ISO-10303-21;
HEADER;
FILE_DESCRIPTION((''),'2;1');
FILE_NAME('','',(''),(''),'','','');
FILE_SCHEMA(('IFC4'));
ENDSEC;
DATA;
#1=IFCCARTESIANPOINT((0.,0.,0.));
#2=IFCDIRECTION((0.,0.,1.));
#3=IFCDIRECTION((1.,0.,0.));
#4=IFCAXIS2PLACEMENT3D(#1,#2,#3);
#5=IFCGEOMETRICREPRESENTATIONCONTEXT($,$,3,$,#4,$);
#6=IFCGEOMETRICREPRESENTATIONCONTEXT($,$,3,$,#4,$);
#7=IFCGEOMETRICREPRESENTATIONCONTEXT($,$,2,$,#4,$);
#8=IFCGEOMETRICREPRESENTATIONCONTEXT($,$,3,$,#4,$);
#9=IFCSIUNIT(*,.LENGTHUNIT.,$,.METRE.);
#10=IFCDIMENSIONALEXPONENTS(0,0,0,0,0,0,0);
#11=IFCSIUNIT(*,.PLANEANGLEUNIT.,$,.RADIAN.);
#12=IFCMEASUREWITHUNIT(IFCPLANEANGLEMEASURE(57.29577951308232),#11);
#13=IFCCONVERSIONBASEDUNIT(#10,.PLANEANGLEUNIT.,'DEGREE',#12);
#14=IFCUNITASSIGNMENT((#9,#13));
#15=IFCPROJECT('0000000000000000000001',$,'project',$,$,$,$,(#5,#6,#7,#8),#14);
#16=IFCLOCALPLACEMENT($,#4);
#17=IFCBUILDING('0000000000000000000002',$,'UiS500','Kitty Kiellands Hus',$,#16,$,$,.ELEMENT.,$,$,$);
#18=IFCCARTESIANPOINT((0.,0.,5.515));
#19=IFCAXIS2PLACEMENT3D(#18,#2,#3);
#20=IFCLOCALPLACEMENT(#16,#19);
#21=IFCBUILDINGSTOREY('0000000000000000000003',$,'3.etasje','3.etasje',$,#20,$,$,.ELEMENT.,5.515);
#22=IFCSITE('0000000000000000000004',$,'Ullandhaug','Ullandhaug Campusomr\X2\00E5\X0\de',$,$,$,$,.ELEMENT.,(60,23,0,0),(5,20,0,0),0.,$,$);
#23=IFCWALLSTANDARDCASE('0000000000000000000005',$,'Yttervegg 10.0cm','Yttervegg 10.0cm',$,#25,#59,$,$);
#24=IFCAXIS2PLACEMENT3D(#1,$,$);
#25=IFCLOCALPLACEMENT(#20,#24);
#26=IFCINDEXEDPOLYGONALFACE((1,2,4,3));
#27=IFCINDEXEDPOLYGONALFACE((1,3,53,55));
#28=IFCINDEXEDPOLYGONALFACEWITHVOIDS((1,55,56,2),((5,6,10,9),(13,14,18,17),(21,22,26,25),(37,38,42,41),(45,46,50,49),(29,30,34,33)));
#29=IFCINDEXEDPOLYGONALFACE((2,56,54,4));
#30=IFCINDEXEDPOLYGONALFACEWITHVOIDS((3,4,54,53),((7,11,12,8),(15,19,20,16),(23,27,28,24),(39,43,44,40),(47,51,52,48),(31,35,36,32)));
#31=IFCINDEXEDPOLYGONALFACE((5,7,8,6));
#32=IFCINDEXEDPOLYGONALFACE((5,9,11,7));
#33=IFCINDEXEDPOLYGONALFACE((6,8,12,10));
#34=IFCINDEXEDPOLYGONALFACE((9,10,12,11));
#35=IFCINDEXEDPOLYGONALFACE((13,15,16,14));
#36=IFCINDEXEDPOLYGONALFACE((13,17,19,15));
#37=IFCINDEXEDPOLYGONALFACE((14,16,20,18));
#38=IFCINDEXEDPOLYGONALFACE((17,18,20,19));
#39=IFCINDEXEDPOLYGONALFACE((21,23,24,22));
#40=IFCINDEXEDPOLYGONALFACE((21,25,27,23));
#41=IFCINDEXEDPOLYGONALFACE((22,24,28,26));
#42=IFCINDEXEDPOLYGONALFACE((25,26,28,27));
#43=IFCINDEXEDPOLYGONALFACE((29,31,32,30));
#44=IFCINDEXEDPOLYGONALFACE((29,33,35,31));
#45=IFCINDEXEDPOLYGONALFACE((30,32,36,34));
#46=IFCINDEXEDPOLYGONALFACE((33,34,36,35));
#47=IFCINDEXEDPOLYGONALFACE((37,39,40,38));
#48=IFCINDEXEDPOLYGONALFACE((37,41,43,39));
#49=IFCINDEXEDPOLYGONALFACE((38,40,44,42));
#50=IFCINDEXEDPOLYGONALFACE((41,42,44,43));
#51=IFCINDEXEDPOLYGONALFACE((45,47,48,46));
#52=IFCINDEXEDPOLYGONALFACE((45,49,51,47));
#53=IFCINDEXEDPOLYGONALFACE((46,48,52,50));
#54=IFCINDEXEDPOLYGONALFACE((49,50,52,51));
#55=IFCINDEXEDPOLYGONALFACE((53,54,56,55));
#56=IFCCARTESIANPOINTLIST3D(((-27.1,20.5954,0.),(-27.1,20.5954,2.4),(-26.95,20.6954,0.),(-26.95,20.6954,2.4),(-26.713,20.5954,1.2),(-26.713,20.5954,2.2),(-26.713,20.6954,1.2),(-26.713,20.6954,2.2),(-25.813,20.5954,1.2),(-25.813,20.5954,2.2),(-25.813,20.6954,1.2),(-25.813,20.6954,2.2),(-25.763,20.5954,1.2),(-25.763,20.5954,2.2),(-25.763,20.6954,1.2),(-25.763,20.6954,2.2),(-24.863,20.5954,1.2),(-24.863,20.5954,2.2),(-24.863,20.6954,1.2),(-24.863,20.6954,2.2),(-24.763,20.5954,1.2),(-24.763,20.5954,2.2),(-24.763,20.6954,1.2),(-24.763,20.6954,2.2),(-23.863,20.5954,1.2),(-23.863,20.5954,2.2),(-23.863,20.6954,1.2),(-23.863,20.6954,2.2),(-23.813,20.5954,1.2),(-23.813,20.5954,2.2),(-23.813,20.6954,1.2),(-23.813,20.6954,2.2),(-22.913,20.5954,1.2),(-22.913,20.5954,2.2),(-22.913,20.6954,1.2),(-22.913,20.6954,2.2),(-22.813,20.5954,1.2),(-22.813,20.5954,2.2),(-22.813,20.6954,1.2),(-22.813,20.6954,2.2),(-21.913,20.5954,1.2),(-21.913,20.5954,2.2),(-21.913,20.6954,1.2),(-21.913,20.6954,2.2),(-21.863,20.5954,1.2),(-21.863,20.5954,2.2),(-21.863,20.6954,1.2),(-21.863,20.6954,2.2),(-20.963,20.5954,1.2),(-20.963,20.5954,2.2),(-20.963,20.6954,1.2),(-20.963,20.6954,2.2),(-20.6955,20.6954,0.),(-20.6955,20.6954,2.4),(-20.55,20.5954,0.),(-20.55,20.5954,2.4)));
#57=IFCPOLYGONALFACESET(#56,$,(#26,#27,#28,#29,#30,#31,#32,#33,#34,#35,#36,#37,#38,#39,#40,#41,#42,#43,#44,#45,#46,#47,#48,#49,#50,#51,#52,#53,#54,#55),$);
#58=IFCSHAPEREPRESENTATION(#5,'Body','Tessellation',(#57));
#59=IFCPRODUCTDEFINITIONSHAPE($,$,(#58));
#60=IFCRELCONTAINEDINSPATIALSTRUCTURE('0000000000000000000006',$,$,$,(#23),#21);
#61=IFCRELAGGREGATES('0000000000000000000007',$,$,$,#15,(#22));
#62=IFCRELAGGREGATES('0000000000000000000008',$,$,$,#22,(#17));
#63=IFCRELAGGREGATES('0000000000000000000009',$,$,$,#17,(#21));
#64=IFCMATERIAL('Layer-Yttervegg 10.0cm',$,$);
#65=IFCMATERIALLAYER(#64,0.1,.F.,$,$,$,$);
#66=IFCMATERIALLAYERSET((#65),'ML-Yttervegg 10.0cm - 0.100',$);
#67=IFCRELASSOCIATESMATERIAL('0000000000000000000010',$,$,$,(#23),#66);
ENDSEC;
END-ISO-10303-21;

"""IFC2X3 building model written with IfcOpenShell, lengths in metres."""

from ifc_helpers import new_model, entity, si_unit, converted_unit, frame, origin_with_axes, place, context, project, spatial, polyline, outline, extrude, material, layer, layer_set, layer_usage, element, save


model = new_model("IFC2X3")

# Units and contexts
context_of_model_1 = context(None, 3, world=origin_with_axes())
context_of_model_2 = context(None, 3, world=origin_with_axes())
context_of_model_3 = context(None, 2, world=origin_with_axes())
context_of_model_4 = context(None, 3, world=origin_with_axes())
ifc_project = project(units=[si_unit("LENGTHUNIT", "METRE"), converted_unit("PLANEANGLEUNIT", "DEGREE", entity("IfcPlaneAngleMeasure", 57.29577951308232), si_unit("PLANEANGLEUNIT", "RADIAN"), dimensions=[0, 0, 0, 0, 0, 0, 0])], contexts=[context_of_model_1, context_of_model_2, context_of_model_3, context_of_model_4])

# Site, building, storey
site = spatial("IfcSite", under=ifc_project, Name="Ullandhaug", Description="Ullandhaug Campusområde", CompositionType="ELEMENT", RefLatitude=(60, 23, 0, 0), RefLongitude=(5, 20, 0, 0), RefElevation=0.0)
building_placement = place(None, origin_with_axes())
building = spatial("IfcBuilding", under=site, at=building_placement, Name="UiS500", Description="Kitty Kiellands Hus", CompositionType="ELEMENT")
storey_placement = place(building_placement, frame((0.0, 0.0, 5.515), z_axis=(0.0, 0.0, 1.0), x_axis=(1.0, 0.0, 0.0)))
storey = spatial("IfcBuildingStorey", under=building, at=storey_placement, Name="3.etasje", Description="3.etasje", CompositionType="ELEMENT", Elevation=5.515)

# Wall, openings
ifc_material_1 = material(Name="Layer-Yttervegg 10.0cm")
ifc_layer_1 = layer(ifc_material_1, 0.1, ventilated=False)
ifc_layer_set_1 = layer_set([ifc_layer_1], Name="ML-Yttervegg 10.0cm - 0.100")
ifc_layer_usage_1 = layer_usage(ifc_layer_set_1, "AXIS2", "POSITIVE", 0.0)
wall_1_placement = place(storey_placement, frame((-20.6955, 20.6954, 0.0), z_axis=(0.0, 0.0, 1.0), x_axis=(-1.0, 0.0, 0.0)))
wall_1 = element("IfcWallStandardCase", 1, at=wall_1_placement, inside=storey, material=ifc_layer_usage_1, Name="Yttervegg 10.0cm", Description="Yttervegg 10.0cm", context=context_of_model_1, shape_type="SweptSolid", body=[
    extrude(outline(polyline([(0.0, 0.0), (6.2545, 0.0), (6.4045, 0.1), (-0.1455, 0.1), (0.0, 0.0)])), frame((0.0, 0.0, 0.0), z_axis=(0.0, 0.0, 1.0), x_axis=(1.0, 0.0, 0.0)), (0.0, 0.0, 1.0), 2.4),
])
opening_1_placement = place(wall_1_placement, frame((4.1675, 0.1, 1.2), z_axis=(0.0, 0.0, 1.0), x_axis=(1.0, 0.0, 0.0)))
element("IfcOpeningElement", 2, at=opening_1_placement, cuts=wall_1, context=context_of_model_1, shape_type="SweptSolid", body=[
    extrude(outline(polyline([(0.0, 0.0), (1.0, 0.0), (1.0, 0.9), (0.0, 0.9), (0.0, 0.0)])), frame((0.0, 0.0, 0.0), z_axis=(0.0, 1.0, 0.0), x_axis=(0.0, 0.0, 1.0)), (0.0, 0.0, -1.0), 0.1),
])
opening_2_placement = place(wall_1_placement, frame((3.1675, 0.1, 1.2), z_axis=(0.0, 0.0, 1.0), x_axis=(1.0, 0.0, 0.0)))
element("IfcOpeningElement", 3, at=opening_2_placement, cuts=wall_1, context=context_of_model_1, shape_type="SweptSolid", body=[
    extrude(outline(polyline([(0.0, 0.0), (1.0, 0.0), (1.0, 0.9), (0.0, 0.9), (0.0, 0.0)])), frame((0.0, 0.0, 0.0), z_axis=(0.0, 1.0, 0.0), x_axis=(0.0, 0.0, 1.0)), (0.0, 0.0, -1.0), 0.1),
])
opening_3_placement = place(wall_1_placement, frame((2.2175, 0.1, 1.2), z_axis=(0.0, 0.0, 1.0), x_axis=(1.0, 0.0, 0.0)))
element("IfcOpeningElement", 4, at=opening_3_placement, cuts=wall_1, context=context_of_model_1, shape_type="SweptSolid", body=[
    extrude(outline(polyline([(0.0, 0.0), (1.0, 0.0), (1.0, 0.9), (0.0, 0.9), (0.0, 0.0)])), frame((0.0, 0.0, 0.0), z_axis=(0.0, 1.0, 0.0), x_axis=(0.0, 0.0, 1.0)), (0.0, 0.0, -1.0), 0.1),
])
opening_4_placement = place(wall_1_placement, frame((1.2175, 0.1, 1.2), z_axis=(0.0, 0.0, 1.0), x_axis=(1.0, 0.0, 0.0)))
element("IfcOpeningElement", 5, at=opening_4_placement, cuts=wall_1, context=context_of_model_1, shape_type="SweptSolid", body=[
    extrude(outline(polyline([(0.0, 0.0), (1.0, 0.0), (1.0, 0.9), (0.0, 0.9), (0.0, 0.0)])), frame((0.0, 0.0, 0.0), z_axis=(0.0, 1.0, 0.0), x_axis=(0.0, 0.0, 1.0)), (0.0, 0.0, -1.0), 0.1),
])
opening_5_placement = place(wall_1_placement, frame((0.2675, 0.1, 1.2), z_axis=(0.0, 0.0, 1.0), x_axis=(1.0, 0.0, 0.0)))
element("IfcOpeningElement", 6, at=opening_5_placement, cuts=wall_1, context=context_of_model_1, shape_type="SweptSolid", body=[
    extrude(outline(polyline([(0.0, 0.0), (1.0, 0.0), (1.0, 0.9), (0.0, 0.9), (0.0, 0.0)])), frame((0.0, 0.0, 0.0), z_axis=(0.0, 1.0, 0.0), x_axis=(0.0, 0.0, 1.0)), (0.0, 0.0, -1.0), 0.1),
])
opening_6_placement = place(wall_1_placement, frame((5.1175, 0.1, 1.2), z_axis=(0.0, 0.0, 1.0), x_axis=(1.0, 0.0, 0.0)))
element("IfcOpeningElement", 7, at=opening_6_placement, cuts=wall_1, context=context_of_model_1, shape_type="SweptSolid", body=[
    extrude(outline(polyline([(0.0, 0.0), (1.0, 0.0), (1.0, 0.9), (0.0, 0.9), (0.0, 0.0)])), frame((0.0, 0.0, 0.0), z_axis=(0.0, 1.0, 0.0), x_axis=(0.0, 0.0, 1.0)), (0.0, 0.0, -1.0), 0.1),
])

save(model, "model.ifc")
